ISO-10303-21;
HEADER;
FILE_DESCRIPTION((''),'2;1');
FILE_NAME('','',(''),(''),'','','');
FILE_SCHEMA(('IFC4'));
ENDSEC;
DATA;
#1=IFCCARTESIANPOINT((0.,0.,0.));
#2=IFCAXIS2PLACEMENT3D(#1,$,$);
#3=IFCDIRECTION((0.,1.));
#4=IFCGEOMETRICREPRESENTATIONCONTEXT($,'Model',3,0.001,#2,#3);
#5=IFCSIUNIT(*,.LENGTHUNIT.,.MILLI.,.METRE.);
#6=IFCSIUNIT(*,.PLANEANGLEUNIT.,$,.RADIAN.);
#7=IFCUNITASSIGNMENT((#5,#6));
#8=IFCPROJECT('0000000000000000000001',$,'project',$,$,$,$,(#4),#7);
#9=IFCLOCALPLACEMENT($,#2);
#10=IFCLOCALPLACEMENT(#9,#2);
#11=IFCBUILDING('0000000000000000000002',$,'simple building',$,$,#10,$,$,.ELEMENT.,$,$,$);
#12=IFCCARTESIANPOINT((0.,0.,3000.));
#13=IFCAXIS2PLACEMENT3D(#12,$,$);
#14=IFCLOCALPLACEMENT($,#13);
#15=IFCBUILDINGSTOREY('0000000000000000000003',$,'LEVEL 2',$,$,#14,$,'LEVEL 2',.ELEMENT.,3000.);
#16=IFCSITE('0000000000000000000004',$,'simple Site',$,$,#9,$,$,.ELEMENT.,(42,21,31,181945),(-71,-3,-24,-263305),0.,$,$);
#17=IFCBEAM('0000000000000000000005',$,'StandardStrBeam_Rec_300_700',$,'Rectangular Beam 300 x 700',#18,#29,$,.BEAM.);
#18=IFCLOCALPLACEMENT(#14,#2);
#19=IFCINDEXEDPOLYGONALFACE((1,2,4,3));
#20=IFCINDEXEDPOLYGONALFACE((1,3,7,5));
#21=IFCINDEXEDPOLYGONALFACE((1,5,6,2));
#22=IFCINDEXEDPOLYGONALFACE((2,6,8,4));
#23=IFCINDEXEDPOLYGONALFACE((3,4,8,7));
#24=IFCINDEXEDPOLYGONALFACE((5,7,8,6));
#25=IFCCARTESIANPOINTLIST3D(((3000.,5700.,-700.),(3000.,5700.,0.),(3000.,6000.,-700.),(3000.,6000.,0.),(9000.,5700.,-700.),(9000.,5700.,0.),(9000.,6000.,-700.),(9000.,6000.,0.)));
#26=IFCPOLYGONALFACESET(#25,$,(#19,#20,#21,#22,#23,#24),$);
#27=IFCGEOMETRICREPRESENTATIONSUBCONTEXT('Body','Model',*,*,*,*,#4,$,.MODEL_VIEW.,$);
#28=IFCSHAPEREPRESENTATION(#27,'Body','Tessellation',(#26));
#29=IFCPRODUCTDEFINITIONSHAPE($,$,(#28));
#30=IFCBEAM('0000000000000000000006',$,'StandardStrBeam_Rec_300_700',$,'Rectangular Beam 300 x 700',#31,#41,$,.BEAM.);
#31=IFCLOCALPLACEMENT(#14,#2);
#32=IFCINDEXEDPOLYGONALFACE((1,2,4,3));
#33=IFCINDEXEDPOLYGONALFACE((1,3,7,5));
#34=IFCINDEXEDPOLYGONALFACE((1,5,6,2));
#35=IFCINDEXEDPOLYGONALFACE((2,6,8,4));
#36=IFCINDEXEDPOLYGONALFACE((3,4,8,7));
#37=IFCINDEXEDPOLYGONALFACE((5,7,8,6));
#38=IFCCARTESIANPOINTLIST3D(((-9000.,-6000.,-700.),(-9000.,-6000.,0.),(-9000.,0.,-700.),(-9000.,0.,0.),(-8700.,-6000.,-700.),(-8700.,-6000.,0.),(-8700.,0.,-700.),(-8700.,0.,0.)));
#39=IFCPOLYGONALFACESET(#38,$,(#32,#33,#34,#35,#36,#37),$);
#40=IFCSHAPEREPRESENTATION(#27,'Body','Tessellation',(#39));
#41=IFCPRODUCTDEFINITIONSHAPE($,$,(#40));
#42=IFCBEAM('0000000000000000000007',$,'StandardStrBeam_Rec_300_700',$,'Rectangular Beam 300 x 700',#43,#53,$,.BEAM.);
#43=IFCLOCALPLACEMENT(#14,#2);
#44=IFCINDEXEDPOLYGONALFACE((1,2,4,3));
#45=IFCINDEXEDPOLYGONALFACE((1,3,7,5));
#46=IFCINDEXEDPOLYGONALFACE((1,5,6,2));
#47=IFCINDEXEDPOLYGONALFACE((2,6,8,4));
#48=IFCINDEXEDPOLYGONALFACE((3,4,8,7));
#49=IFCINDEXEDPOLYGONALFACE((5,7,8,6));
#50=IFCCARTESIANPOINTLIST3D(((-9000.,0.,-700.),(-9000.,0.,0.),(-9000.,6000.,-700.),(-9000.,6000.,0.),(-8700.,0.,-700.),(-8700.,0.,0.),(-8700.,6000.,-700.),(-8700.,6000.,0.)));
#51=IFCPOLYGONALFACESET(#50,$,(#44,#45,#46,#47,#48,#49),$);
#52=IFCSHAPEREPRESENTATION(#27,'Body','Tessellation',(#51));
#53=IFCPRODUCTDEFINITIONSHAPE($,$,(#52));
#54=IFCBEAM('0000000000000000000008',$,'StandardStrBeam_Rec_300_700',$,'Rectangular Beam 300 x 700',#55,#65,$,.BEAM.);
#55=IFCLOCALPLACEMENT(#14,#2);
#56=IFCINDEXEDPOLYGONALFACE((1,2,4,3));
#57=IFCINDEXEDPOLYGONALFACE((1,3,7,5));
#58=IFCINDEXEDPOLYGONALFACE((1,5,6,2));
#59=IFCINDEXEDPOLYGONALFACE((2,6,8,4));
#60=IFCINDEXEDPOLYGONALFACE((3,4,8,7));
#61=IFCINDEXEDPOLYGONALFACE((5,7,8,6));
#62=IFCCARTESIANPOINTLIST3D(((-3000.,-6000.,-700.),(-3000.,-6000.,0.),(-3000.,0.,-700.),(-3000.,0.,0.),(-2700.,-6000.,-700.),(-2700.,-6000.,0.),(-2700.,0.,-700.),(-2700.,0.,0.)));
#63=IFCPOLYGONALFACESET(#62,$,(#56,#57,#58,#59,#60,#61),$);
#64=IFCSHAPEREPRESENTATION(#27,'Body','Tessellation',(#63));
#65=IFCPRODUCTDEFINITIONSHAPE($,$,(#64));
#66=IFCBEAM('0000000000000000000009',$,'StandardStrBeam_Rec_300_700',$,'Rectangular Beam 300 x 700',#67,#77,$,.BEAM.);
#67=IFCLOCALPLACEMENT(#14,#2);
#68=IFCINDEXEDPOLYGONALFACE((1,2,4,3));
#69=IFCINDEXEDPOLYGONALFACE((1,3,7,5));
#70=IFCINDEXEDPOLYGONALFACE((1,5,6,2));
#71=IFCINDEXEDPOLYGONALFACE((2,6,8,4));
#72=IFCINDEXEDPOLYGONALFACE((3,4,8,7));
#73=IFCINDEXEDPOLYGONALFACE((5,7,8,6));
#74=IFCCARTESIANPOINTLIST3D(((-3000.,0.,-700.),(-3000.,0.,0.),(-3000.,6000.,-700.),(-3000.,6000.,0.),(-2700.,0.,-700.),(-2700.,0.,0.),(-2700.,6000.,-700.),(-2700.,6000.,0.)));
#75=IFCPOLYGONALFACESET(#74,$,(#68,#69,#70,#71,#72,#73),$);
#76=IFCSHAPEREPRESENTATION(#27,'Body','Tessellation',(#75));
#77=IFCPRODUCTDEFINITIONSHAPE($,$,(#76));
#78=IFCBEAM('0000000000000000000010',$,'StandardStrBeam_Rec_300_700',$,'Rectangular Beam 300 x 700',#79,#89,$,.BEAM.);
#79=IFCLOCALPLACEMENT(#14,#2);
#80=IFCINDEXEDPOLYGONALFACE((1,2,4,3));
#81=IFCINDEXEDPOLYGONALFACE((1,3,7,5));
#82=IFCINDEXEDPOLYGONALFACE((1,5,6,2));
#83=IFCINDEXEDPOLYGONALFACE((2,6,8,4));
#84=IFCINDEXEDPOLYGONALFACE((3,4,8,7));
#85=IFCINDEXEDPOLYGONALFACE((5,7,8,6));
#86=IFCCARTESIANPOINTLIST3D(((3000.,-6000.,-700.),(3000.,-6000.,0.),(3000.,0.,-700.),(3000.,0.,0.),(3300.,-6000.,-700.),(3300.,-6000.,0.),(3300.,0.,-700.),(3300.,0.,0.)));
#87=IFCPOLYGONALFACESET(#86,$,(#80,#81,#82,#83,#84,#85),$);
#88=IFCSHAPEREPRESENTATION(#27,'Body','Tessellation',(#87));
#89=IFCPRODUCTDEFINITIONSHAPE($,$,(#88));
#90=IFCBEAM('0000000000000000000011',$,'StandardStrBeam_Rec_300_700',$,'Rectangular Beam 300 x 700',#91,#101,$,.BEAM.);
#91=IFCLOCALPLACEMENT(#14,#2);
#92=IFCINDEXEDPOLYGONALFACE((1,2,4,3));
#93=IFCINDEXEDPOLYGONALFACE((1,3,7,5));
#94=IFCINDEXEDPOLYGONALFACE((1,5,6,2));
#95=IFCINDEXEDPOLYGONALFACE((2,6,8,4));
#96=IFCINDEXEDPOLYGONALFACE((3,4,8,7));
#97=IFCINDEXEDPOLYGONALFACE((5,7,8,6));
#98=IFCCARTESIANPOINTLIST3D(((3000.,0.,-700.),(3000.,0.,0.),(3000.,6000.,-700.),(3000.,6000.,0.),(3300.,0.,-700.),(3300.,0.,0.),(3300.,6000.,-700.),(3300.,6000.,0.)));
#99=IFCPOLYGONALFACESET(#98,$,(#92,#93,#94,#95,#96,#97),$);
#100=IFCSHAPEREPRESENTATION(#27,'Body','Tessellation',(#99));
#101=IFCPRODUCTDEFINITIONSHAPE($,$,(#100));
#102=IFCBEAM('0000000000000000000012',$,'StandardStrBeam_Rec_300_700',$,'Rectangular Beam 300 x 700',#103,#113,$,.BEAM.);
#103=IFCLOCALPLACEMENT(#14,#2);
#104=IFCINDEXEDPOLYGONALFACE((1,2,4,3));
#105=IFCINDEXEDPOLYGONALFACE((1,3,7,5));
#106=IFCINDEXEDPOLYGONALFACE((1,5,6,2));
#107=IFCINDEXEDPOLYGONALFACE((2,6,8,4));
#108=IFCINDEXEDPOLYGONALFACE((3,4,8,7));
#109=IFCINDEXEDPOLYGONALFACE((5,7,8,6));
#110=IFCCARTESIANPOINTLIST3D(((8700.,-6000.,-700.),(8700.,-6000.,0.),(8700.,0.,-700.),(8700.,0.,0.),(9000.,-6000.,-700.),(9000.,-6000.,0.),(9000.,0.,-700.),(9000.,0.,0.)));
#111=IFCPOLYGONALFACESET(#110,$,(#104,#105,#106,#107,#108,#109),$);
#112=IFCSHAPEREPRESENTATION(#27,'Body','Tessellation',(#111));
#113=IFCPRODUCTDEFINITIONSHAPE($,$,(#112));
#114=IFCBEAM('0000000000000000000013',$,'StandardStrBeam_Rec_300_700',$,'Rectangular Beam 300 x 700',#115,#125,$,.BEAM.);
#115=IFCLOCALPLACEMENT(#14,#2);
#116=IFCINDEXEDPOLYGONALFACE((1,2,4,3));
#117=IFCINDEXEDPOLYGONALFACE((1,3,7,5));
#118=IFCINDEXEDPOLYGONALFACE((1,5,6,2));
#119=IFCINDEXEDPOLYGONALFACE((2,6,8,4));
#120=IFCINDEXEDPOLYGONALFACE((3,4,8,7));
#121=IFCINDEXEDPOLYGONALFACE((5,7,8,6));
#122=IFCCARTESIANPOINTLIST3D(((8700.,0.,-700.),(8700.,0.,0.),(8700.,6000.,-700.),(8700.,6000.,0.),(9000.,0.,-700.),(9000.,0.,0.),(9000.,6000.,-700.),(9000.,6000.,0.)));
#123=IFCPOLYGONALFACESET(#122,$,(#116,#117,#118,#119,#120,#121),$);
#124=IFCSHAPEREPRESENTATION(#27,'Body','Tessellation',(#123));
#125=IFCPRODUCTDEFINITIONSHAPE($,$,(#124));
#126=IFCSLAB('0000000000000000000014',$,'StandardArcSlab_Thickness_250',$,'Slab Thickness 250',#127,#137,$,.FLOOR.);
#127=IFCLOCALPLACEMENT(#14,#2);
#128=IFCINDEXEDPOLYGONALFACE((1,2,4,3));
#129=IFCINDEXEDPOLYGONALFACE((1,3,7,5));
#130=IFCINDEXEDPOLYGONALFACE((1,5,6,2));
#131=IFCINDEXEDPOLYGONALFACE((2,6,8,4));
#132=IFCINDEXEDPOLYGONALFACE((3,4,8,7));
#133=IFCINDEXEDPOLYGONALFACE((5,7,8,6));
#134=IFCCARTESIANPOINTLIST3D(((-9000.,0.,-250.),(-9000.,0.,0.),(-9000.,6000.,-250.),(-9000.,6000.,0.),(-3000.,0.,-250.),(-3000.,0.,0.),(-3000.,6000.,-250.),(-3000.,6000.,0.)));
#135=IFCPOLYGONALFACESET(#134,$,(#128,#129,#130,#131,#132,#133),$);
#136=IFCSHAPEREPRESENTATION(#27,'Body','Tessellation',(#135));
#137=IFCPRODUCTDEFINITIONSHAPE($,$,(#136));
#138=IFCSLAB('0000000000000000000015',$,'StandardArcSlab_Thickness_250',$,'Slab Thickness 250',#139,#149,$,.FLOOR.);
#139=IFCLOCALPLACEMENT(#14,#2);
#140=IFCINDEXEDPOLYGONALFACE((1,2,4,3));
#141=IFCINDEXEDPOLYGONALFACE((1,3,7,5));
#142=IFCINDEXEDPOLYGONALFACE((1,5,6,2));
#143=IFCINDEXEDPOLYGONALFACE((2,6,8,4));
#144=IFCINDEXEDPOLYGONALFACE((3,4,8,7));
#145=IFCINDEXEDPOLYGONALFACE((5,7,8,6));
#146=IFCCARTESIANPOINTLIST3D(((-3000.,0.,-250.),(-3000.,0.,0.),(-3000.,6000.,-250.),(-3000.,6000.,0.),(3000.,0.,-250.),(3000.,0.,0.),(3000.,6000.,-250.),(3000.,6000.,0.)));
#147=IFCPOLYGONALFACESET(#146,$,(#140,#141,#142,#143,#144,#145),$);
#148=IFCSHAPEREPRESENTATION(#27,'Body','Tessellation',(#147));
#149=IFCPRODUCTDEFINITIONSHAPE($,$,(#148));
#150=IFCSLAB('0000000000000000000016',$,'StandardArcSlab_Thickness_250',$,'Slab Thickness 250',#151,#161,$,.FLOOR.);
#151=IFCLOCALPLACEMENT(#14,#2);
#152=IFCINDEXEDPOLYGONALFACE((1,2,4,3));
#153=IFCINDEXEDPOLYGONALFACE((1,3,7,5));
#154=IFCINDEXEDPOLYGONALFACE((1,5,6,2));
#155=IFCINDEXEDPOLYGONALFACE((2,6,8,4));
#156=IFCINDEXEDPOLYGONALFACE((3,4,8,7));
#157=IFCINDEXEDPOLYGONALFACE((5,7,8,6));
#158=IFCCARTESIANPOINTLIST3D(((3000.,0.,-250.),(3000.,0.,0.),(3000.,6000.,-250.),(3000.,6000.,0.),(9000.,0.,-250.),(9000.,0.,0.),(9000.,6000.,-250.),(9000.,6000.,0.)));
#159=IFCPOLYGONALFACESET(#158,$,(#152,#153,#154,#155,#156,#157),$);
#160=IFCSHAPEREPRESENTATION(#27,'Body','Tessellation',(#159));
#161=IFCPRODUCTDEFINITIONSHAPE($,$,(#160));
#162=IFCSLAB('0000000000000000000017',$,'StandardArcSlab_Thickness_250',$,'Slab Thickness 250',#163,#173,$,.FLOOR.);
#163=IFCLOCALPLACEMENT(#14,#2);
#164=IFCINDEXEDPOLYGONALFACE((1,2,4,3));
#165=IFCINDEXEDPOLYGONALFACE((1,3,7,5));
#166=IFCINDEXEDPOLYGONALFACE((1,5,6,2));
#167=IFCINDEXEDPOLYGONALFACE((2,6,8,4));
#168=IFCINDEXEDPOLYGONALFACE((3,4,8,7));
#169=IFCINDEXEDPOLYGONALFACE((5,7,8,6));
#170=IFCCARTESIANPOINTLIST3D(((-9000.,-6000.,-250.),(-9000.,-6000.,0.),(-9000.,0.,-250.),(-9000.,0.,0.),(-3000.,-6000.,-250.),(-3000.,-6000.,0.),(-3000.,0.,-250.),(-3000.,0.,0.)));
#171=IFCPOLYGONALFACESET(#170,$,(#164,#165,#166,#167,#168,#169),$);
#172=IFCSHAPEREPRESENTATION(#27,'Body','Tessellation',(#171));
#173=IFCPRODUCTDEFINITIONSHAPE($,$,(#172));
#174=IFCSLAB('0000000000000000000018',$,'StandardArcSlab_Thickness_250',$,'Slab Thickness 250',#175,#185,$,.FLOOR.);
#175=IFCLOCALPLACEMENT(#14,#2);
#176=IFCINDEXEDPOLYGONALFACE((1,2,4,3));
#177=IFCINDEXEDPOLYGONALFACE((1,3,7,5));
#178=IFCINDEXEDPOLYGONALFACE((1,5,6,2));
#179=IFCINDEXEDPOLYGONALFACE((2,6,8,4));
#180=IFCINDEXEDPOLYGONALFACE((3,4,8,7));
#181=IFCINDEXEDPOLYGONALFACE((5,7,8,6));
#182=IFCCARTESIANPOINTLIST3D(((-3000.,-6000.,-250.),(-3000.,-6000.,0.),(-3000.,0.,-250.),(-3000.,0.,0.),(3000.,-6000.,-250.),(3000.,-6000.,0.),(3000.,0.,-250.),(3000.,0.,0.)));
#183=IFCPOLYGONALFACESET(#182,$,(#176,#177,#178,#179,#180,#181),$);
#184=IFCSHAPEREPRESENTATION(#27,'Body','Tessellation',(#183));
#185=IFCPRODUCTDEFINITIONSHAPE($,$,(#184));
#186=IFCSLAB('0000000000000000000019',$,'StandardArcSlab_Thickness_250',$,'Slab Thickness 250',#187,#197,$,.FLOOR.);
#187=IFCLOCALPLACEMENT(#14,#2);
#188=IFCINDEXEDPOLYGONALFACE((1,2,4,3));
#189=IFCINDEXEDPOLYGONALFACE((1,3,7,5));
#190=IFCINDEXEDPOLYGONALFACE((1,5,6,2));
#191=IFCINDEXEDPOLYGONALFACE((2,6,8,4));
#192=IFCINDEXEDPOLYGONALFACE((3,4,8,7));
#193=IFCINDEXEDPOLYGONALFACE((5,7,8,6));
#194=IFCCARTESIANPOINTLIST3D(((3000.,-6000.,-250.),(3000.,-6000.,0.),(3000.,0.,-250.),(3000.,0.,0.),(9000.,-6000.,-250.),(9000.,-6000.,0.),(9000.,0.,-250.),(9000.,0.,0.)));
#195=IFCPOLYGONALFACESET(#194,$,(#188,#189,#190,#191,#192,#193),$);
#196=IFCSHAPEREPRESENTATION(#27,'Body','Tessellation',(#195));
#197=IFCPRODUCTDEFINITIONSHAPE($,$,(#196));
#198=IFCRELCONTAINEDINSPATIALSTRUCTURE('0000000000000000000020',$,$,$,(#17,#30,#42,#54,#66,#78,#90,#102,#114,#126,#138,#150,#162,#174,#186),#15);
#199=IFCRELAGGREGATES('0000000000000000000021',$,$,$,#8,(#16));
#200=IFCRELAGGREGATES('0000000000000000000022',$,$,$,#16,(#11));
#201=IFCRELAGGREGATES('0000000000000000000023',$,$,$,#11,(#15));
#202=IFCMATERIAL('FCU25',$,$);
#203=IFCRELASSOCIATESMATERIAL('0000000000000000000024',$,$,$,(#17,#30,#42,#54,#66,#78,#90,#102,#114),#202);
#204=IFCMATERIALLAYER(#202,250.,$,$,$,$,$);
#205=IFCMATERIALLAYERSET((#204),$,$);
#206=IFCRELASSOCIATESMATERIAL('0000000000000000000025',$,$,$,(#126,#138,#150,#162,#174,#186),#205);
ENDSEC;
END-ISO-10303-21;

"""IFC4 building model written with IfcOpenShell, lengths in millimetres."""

from ifc_helpers import new_model, si_unit, direction, frame, origin, origin_with_axes, origin_2d_with_axis, place, context, subcontext, project, spatial, polyline, rectangle, outline, extrude, material, layer, layer_set, layer_usage, material_profile, profile_set, profile_usage, element, save


model = new_model("IFC4")

# Units and contexts
model_context = context("Model", 3, precision=0.001, world=origin(), true_north=direction((0.0, 1.0)))
body_context = subcontext(model_context, "Body", "Model", "MODEL_VIEW")
ifc_project = project(units=[si_unit("LENGTHUNIT", "METRE", prefix="MILLI"), si_unit("PLANEANGLEUNIT", "RADIAN")], contexts=[model_context])

# Site, building, storey
site_placement = place(None, origin())
site = spatial("IfcSite", under=ifc_project, at=site_placement, Name="simple Site", CompositionType="ELEMENT", RefLatitude=(42, 21, 31, 181945), RefLongitude=(-71, -3, -24, -263305), RefElevation=0.0)
building_placement = place(site_placement, origin())
building = spatial("IfcBuilding", under=site, at=building_placement, Name="simple building", CompositionType="ELEMENT")
storey_placement = place(None, frame((0.0, 0.0, 3000.0)))
storey = spatial("IfcBuildingStorey", under=building, at=storey_placement, Name="LEVEL 2", LongName="LEVEL 2", CompositionType="ELEMENT", Elevation=3000.0)

# Beams
ifc_material_1 = material(Name="FCU25")
ifc_material_profile_1 = material_profile(ifc_material_1, rectangle(XDim=300.0, YDim=700.0, at=origin_2d_with_axis()))
ifc_profile_set_1 = profile_set([ifc_material_profile_1])
ifc_profile_usage_1 = profile_usage(ifc_profile_set_1, cardinal=9)
ifc_profile_usage_2 = profile_usage(ifc_profile_set_1, cardinal=7)
for number, where, z_axis, x_axis, name in (
    (1, (3000.0, 5850.0, 2650.0), (1.0, 0.0, 0.0), (0.0, -1.0, 0.0), "StandardStrBeam_Rec_300_700"),
    (2, (-8850.0, -6000.0, 2650.0), (0.0, 1.0, 0.0), (1.0, 0.0, 0.0), "StandardStrBeam_Rec_300_700"),
    (3, (-8850.0, 0.0, 2650.0), (0.0, 1.0, 0.0), (1.0, 0.0, 0.0), "StandardStrBeam_Rec_300_700"),
    (4, (-2850.0, -6000.0, 2650.0), (0.0, 1.0, 0.0), (1.0, 0.0, 0.0), "StandardStrBeam_Rec_300_700"),
    (5, (-2850.0, 0.0, 2650.0), (0.0, 1.0, 0.0), (1.0, 0.0, 0.0), "StandardStrBeam_Rec_300_700"),
    (6, (3150.0, -6000.0, 2650.0), (0.0, 1.0, 0.0), (1.0, 0.0, 0.0), "StandardStrBeam_Rec_300_700"),
    (7, (3150.0, 0.0, 2650.0), (0.0, 1.0, 0.0), (1.0, 0.0, 0.0), "StandardStrBeam_Rec_300_700"),
):
    element("IfcBeam", number, at=place(None, frame(where, z_axis=z_axis, x_axis=x_axis)), inside=storey, material=ifc_profile_usage_2, Name=name, ObjectType="Rectangular Beam 300 x 700", PredefinedType="BEAM", context=body_context, shape_type="SweptSolid", body=[
        extrude(rectangle(XDim=300.0, YDim=700.0, at=origin_2d_with_axis()), origin_with_axes(), (0.0, 0.0, 1.0), 6000.0),
    ])
for number, where, z_axis, x_axis, name in (
    (8, (8850.0, -6000.0, 2650.0), (0.0, 1.0, 0.0), (1.0, 0.0, 0.0), "StandardStrBeam_Rec_300_700"),
    (9, (8850.0, 0.0, 2650.0), (0.0, 1.0, 0.0), (1.0, 0.0, 0.0), "StandardStrBeam_Rec_300_700"),
):
    element("IfcBeam", number, at=place(None, frame(where, z_axis=z_axis, x_axis=x_axis)), inside=storey, material=ifc_profile_usage_1, Name=name, ObjectType="Rectangular Beam 300 x 700", PredefinedType="BEAM", context=body_context, shape_type="SweptSolid", body=[
        extrude(rectangle(XDim=300.0, YDim=700.0, at=origin_2d_with_axis()), origin_with_axes(), (0.0, 0.0, 1.0), 6000.0),
    ])

# Slabs
ifc_layer = layer(ifc_material_1, 250.0)
ifc_layer_set = layer_set([ifc_layer])
ifc_layer_usage = layer_usage(ifc_layer_set, "AXIS3", "POSITIVE", -250.0)
for number, where, z_axis, x_axis, name in (
    (10, (-9000.0, 0.0, 2750.0), (0.0, 0.0, 1.0), (1.0, 0.0, 0.0), "StandardArcSlab_Thickness_250"),
    (11, (-3000.0, 0.0, 2750.0), (0.0, 0.0, 1.0), (1.0, 0.0, 0.0), "StandardArcSlab_Thickness_250"),
    (12, (3000.0, 0.0, 2750.0), (0.0, 0.0, 1.0), (1.0, 0.0, 0.0), "StandardArcSlab_Thickness_250"),
    (13, (-9000.0, -6000.0, 2750.0), (0.0, 0.0, 1.0), (1.0, 0.0, 0.0), "StandardArcSlab_Thickness_250"),
    (14, (-3000.0, -6000.0, 2750.0), (0.0, 0.0, 1.0), (1.0, 0.0, 0.0), "StandardArcSlab_Thickness_250"),
    (15, (3000.0, -6000.0, 2750.0), (0.0, 0.0, 1.0), (1.0, 0.0, 0.0), "StandardArcSlab_Thickness_250"),
):
    element("IfcSlab", number, at=place(None, frame(where, z_axis=z_axis, x_axis=x_axis)), inside=storey, material=ifc_layer_usage, Name=name, ObjectType="Slab Thickness 250", PredefinedType="FLOOR", context=body_context, shape_type="SweptSolid", body=[
        extrude(outline(polyline([(0.0, 0.0), (6000.0, 0.0), (6000.0, 6000.0), (0.0, 6000.0), (0.0, 0.0)])), origin_with_axes(), (0.0, 0.0, 1.0), 250.0),
    ])

save(model, "model.ifc")
